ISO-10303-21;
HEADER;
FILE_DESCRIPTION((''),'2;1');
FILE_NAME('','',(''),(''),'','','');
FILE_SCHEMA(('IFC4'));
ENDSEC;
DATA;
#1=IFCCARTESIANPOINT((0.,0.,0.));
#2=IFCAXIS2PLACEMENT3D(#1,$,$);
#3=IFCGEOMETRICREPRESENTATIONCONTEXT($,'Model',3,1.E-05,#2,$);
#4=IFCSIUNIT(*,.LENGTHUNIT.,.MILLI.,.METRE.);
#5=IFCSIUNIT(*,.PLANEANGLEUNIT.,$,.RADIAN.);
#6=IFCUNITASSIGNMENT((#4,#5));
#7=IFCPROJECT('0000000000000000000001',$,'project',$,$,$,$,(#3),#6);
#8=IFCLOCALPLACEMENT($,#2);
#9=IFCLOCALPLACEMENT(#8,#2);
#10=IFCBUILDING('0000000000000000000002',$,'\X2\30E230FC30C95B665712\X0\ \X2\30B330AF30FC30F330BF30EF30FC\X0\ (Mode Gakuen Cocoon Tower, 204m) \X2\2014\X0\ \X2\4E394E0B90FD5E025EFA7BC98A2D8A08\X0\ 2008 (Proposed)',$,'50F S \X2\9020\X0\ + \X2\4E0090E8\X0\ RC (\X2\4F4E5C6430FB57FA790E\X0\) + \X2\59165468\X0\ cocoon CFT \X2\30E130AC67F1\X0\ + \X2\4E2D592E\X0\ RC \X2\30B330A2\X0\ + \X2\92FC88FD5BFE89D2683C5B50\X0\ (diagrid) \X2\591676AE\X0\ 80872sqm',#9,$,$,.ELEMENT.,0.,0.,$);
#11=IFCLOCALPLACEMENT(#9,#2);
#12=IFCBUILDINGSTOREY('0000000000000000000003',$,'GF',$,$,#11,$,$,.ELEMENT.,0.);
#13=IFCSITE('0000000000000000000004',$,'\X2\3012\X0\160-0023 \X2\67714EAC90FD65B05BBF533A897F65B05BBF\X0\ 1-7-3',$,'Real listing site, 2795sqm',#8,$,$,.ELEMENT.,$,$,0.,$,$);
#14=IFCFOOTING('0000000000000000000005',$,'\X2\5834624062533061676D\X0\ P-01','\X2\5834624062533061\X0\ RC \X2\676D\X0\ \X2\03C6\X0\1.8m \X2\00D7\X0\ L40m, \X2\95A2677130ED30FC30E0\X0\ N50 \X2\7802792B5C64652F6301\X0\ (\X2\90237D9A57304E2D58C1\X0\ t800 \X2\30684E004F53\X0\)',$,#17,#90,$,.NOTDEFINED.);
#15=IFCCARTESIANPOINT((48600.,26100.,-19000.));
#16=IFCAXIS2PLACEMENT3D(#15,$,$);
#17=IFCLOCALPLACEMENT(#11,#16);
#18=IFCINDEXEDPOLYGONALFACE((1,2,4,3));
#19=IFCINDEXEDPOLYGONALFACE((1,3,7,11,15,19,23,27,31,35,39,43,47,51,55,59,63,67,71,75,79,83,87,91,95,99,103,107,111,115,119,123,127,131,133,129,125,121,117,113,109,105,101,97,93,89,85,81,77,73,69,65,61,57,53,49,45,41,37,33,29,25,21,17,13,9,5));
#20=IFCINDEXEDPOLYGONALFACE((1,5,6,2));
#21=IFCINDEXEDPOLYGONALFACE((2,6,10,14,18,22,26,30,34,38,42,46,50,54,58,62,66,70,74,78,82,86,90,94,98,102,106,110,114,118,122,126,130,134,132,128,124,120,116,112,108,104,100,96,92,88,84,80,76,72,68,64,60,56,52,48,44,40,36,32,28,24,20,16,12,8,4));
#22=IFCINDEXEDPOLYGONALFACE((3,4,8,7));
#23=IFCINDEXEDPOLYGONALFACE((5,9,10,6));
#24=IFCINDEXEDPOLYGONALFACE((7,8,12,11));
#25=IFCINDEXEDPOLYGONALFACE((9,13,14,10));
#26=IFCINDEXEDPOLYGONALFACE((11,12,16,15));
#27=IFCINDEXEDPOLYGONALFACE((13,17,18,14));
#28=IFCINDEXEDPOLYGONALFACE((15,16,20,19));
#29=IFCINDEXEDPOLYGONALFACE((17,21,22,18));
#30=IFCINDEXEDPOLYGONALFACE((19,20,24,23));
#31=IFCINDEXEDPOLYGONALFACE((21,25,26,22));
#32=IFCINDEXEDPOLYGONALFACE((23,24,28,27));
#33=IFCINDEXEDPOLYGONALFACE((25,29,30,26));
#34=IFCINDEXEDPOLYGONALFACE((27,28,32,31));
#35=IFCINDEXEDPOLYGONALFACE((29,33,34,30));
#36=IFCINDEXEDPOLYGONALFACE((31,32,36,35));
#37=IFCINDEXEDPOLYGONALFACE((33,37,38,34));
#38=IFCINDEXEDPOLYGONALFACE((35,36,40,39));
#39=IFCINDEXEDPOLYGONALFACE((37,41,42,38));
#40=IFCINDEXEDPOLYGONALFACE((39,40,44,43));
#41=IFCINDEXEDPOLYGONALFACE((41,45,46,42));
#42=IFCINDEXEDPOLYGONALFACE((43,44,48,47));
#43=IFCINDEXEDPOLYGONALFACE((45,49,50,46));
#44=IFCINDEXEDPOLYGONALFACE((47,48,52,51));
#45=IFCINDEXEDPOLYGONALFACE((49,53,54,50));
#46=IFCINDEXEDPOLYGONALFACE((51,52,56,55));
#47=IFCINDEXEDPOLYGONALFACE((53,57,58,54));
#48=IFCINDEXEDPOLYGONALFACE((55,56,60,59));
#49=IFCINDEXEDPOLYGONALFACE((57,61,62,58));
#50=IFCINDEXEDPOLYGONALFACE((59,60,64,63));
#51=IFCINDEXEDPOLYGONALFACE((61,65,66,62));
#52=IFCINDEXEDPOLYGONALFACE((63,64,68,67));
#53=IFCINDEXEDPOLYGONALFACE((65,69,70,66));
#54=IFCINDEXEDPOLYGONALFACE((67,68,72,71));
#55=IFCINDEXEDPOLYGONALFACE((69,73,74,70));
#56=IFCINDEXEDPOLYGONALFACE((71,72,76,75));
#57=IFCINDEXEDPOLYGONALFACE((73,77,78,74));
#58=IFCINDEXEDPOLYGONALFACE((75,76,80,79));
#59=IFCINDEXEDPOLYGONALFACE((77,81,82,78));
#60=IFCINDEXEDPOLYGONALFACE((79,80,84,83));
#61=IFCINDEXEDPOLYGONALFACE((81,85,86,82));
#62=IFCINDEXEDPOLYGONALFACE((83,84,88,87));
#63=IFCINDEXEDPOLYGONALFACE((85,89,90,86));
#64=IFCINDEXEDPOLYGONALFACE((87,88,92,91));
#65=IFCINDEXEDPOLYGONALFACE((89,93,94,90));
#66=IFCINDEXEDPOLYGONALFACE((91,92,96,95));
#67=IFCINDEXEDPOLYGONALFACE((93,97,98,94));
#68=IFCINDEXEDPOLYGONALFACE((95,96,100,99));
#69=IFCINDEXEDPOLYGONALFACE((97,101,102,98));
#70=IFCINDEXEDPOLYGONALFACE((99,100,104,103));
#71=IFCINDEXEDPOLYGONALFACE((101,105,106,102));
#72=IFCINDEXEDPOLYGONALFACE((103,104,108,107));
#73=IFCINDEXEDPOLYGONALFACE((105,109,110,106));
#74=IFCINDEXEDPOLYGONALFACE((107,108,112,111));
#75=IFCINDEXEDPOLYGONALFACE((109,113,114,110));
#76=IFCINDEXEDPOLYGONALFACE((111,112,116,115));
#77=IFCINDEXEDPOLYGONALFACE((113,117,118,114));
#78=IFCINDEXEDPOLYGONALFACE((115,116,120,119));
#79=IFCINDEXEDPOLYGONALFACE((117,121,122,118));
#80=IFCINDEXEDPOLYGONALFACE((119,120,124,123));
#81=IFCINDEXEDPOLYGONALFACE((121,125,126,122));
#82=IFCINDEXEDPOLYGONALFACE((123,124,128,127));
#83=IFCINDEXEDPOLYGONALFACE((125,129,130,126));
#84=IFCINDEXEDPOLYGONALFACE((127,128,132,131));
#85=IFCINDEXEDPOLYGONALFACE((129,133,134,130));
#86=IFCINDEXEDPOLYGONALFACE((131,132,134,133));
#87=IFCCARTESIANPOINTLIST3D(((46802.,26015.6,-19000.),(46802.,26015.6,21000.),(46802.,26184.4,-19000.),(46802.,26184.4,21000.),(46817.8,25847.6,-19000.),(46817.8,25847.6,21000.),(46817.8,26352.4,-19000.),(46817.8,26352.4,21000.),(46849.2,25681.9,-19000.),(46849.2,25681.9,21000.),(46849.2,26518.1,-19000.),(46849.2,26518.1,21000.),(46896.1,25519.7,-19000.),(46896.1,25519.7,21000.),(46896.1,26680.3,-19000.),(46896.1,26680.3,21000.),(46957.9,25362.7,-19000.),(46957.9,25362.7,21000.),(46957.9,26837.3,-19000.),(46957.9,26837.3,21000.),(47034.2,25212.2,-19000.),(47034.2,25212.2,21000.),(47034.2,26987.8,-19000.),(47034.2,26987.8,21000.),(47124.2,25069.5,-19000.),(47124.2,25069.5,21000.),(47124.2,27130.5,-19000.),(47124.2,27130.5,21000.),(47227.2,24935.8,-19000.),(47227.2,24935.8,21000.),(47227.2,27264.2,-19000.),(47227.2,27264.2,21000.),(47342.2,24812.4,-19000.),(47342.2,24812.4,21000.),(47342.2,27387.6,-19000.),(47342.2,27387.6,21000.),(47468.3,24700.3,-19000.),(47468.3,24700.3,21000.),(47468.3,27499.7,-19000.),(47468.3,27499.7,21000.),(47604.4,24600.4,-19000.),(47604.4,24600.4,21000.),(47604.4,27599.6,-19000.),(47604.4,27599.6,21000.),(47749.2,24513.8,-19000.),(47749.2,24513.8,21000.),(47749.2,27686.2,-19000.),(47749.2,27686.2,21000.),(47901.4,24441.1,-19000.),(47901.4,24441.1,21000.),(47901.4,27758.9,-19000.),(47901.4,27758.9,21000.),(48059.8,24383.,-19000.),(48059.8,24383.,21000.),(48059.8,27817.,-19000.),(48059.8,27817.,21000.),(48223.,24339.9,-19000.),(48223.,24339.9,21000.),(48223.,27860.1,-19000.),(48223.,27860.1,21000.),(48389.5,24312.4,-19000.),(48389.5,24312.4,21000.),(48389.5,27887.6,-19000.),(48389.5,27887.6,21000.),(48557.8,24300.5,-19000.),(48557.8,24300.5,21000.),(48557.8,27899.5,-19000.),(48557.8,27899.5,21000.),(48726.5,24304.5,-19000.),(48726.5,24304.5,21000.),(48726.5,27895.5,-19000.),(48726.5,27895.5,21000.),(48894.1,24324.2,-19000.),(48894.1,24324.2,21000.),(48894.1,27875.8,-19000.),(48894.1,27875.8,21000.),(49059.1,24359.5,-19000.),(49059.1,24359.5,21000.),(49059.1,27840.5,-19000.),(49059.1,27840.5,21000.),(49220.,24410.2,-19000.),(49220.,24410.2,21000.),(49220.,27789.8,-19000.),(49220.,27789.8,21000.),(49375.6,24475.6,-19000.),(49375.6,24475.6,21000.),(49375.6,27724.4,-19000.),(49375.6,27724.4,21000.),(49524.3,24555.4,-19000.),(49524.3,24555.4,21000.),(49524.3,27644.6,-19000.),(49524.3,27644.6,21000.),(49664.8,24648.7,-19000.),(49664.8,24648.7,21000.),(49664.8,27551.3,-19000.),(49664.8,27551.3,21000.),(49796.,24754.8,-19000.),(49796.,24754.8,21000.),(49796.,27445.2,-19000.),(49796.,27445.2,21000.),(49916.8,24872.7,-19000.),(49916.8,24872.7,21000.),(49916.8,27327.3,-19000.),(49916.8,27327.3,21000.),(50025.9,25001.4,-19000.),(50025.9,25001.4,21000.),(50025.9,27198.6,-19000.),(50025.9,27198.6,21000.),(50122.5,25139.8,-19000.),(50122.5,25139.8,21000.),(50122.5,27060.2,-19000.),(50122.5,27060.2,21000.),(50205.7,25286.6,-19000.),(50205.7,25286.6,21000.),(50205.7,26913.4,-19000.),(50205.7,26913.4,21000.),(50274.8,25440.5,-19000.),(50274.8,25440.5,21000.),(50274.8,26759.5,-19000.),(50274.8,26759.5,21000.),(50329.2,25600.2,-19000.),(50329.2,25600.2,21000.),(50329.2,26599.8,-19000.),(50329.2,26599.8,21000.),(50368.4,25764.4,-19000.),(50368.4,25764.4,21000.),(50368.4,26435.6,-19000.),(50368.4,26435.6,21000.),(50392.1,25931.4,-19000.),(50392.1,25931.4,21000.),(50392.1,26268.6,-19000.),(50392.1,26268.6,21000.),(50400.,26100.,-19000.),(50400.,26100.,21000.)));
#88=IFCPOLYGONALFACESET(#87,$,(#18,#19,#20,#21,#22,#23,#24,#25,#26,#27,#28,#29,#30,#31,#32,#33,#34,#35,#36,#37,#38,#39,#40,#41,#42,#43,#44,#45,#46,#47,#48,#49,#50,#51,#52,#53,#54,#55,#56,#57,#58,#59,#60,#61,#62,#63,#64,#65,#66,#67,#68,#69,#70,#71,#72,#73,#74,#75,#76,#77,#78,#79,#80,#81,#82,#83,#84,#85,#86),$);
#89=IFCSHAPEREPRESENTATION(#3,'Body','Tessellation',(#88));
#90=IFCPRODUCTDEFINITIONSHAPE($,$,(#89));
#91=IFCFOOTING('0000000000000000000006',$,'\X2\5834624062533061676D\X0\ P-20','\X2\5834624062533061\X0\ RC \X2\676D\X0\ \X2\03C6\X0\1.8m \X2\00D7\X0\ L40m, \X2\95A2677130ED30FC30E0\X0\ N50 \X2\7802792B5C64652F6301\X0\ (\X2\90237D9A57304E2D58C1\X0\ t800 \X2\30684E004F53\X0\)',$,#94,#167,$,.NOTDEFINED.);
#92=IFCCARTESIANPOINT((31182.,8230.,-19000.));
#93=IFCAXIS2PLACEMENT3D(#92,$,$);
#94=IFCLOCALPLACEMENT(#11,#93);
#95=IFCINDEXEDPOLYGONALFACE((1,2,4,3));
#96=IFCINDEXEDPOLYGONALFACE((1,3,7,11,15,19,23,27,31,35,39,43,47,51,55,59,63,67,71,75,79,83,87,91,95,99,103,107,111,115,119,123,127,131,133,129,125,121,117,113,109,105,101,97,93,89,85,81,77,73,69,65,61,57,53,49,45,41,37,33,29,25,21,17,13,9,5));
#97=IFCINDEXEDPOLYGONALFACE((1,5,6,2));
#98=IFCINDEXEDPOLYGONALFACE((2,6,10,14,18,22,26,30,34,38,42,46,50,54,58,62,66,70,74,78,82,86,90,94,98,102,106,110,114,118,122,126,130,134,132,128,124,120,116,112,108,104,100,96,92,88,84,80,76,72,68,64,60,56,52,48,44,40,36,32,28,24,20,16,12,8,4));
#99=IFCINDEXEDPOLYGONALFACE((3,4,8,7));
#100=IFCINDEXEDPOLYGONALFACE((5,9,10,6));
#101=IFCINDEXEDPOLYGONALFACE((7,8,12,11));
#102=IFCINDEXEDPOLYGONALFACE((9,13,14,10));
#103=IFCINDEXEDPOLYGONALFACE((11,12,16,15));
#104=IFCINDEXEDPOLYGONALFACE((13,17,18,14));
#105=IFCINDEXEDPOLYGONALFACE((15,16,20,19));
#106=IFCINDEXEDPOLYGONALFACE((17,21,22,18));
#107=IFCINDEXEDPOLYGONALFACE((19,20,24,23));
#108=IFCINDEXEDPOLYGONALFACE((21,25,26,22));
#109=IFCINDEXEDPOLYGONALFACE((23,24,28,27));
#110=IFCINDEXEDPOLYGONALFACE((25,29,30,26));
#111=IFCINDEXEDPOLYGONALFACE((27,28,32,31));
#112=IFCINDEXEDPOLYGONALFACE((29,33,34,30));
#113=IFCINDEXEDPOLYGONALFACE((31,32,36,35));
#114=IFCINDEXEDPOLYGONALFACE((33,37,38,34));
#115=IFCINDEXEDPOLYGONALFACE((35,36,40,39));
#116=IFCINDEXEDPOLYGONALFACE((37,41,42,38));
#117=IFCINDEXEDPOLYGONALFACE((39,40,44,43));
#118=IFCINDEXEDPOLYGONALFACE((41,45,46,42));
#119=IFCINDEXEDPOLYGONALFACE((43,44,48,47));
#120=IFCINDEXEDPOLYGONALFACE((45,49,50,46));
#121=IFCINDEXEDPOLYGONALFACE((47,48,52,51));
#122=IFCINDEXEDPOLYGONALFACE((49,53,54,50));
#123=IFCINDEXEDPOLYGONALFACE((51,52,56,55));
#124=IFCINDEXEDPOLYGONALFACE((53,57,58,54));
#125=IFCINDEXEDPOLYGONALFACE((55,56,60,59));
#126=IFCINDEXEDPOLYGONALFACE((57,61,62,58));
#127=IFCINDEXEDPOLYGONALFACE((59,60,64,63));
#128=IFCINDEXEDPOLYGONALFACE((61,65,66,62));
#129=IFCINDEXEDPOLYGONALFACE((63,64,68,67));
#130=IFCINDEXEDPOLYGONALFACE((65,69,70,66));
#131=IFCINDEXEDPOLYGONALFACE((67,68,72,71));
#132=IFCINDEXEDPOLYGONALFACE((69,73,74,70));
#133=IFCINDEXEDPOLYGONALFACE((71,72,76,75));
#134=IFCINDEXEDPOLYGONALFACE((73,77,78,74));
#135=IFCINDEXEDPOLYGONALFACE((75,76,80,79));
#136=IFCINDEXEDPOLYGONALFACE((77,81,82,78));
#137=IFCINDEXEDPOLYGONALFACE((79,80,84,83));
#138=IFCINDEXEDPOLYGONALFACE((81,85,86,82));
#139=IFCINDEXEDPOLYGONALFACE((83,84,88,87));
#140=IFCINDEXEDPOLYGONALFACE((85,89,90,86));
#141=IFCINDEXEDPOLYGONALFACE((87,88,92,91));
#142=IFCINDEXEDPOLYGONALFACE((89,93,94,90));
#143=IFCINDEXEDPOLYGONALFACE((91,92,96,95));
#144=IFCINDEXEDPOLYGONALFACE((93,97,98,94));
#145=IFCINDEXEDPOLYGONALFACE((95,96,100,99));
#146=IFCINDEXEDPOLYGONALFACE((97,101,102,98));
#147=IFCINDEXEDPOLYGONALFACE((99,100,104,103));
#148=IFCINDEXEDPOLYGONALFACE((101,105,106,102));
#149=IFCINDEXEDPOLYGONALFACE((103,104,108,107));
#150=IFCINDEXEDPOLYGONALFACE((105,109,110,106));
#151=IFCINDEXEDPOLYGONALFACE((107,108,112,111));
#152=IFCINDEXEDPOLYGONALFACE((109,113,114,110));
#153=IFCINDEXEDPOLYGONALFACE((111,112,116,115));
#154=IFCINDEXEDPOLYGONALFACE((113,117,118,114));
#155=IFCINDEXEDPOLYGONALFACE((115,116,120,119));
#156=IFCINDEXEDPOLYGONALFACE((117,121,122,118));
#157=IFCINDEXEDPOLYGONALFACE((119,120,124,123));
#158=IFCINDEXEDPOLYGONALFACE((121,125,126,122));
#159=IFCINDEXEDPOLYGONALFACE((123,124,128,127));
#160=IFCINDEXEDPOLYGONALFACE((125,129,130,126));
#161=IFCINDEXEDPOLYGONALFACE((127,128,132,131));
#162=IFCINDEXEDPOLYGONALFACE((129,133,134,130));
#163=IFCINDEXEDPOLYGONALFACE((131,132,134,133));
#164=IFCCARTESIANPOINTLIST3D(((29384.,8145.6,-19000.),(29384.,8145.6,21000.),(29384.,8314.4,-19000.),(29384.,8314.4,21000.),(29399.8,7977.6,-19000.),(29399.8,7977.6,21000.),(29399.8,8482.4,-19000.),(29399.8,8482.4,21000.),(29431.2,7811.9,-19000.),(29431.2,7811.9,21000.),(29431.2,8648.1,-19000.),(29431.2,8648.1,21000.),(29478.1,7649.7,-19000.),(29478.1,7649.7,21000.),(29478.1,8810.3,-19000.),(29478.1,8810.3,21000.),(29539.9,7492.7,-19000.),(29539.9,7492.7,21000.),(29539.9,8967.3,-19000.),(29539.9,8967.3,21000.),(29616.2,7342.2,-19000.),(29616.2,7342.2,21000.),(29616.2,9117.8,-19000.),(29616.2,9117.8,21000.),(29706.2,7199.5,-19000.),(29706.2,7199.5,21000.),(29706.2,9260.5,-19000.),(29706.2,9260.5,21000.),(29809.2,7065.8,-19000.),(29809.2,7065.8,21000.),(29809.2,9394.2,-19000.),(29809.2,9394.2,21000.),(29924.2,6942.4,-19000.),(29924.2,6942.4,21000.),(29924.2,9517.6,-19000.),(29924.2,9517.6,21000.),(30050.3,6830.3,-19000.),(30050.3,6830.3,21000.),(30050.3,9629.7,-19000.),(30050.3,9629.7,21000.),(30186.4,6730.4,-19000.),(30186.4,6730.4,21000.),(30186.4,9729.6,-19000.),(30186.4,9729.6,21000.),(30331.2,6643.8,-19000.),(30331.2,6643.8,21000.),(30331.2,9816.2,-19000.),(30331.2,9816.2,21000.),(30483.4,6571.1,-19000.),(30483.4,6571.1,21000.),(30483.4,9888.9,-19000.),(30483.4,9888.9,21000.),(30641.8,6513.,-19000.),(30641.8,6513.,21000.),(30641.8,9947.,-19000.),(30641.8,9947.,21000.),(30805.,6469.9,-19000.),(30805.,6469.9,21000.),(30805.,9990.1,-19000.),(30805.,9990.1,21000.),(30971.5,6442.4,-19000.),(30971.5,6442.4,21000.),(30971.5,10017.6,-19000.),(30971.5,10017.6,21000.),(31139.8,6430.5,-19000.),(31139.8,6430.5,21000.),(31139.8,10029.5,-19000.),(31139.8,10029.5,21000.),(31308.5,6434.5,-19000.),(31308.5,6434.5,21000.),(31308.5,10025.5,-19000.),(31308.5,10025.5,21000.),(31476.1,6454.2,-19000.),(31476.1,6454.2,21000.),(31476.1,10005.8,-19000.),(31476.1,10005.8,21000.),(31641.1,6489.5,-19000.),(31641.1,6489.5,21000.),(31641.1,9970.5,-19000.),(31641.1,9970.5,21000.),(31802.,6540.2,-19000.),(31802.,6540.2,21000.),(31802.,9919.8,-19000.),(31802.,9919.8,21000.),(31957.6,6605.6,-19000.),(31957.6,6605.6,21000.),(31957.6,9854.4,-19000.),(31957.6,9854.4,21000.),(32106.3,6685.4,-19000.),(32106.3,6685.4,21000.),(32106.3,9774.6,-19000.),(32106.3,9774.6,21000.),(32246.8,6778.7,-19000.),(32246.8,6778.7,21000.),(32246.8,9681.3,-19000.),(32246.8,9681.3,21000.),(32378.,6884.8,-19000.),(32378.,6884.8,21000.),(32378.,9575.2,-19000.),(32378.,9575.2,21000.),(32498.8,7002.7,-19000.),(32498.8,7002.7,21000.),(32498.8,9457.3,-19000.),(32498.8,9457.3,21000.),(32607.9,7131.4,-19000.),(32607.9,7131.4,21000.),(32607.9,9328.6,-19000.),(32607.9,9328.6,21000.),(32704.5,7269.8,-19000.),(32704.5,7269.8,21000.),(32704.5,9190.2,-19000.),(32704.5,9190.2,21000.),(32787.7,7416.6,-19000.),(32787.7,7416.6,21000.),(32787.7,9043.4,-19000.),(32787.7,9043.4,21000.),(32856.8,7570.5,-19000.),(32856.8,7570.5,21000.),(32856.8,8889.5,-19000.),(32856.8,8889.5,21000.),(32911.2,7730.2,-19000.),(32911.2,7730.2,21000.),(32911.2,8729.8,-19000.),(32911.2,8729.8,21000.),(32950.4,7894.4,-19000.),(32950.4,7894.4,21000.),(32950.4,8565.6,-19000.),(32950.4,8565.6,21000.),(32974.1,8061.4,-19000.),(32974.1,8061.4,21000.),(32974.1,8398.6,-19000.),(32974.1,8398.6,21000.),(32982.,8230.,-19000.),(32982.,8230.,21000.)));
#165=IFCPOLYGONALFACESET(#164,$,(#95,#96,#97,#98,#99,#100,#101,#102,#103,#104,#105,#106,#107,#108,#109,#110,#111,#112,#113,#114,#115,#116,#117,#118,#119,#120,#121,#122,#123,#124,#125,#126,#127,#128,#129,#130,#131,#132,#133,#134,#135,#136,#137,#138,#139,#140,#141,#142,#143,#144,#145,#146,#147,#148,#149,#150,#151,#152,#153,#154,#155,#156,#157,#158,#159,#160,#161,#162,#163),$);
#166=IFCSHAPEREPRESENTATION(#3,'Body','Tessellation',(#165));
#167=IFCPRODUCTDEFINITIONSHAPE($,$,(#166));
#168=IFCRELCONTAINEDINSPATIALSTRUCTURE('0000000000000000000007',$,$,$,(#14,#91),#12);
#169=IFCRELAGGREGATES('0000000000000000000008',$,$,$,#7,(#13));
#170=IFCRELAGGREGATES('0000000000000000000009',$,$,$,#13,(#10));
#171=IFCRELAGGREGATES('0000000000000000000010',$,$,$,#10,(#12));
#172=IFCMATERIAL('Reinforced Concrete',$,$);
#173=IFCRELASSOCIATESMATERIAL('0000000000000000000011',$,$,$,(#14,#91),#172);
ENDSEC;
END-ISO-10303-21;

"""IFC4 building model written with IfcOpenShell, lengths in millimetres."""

from ifc_helpers import new_model, si_unit, frame, origin, origin_2d, place, context, project, spatial, circle, extrude, material, element, save


model = new_model("IFC4")

# Units and contexts
model_context = context("Model", 3, precision=1e-05, world=origin())
ifc_project = project(units=[si_unit("LENGTHUNIT", "METRE", prefix="MILLI"), si_unit("PLANEANGLEUNIT", "RADIAN")], contexts=[model_context])

# Site, building, storey
site_placement = place(None, origin())
site = spatial("IfcSite", under=ifc_project, at=site_placement, Name="〒160-0023 東京都新宿区西新宿 1-7-3", ObjectType="Real listing site, 2795sqm", CompositionType="ELEMENT", RefElevation=0.0)
building_placement = place(site_placement, origin())
building = spatial("IfcBuilding", under=site, at=building_placement, Name="モード学園 コクーンタワー (Mode Gakuen Cocoon Tower, 204m) — 丹下都市建築設計 2008 (Proposed)", ObjectType="50F S 造 + 一部 RC (低層・基礎) + 外周 cocoon CFT メガ柱 + 中央 RC コア + 鋼製対角格子 (diagrid) 外皮 80872sqm", CompositionType="ELEMENT", ElevationOfRefHeight=0.0, ElevationOfTerrain=0.0)
storey_placement = place(building_placement, origin())
storey = spatial("IfcBuildingStorey", under=building, at=storey_placement, Name="GF", CompositionType="ELEMENT", Elevation=0.0)

# Footings
ifc_material_1 = material(Name="Reinforced Concrete")
footing_1_placement = place(storey_placement, frame((48600.0, 26100.0, -19000.0)))
element("IfcFooting", 1, at=footing_1_placement, inside=storey, material=ifc_material_1, Name="場所打ち杭 P-01", Description="場所打ち RC 杭 φ1.8m × L40m, 関東ローム N50 砂礫層支持 (連続地中壁 t800 と一体)", PredefinedType="NOTDEFINED", context=model_context, shape_type="SweptSolid", body=[
    extrude(circle(Radius=1800.0, at=origin_2d()), frame((48600.0, 26100.0, -19000.0)), (0.0, 0.0, 1.0), 40000.0),
])
footing_2_placement = place(storey_placement, frame((31182.0, 8230.0, -19000.0)))
element("IfcFooting", 2, at=footing_2_placement, inside=storey, material=ifc_material_1, Name="場所打ち杭 P-20", Description="場所打ち RC 杭 φ1.8m × L40m, 関東ローム N50 砂礫層支持 (連続地中壁 t800 と一体)", PredefinedType="NOTDEFINED", context=model_context, shape_type="SweptSolid", body=[
    extrude(circle(Radius=1800.0, at=origin_2d()), frame((31182.0, 8230.0, -19000.0)), (0.0, 0.0, 1.0), 40000.0),
])

save(model, "model.ifc")
